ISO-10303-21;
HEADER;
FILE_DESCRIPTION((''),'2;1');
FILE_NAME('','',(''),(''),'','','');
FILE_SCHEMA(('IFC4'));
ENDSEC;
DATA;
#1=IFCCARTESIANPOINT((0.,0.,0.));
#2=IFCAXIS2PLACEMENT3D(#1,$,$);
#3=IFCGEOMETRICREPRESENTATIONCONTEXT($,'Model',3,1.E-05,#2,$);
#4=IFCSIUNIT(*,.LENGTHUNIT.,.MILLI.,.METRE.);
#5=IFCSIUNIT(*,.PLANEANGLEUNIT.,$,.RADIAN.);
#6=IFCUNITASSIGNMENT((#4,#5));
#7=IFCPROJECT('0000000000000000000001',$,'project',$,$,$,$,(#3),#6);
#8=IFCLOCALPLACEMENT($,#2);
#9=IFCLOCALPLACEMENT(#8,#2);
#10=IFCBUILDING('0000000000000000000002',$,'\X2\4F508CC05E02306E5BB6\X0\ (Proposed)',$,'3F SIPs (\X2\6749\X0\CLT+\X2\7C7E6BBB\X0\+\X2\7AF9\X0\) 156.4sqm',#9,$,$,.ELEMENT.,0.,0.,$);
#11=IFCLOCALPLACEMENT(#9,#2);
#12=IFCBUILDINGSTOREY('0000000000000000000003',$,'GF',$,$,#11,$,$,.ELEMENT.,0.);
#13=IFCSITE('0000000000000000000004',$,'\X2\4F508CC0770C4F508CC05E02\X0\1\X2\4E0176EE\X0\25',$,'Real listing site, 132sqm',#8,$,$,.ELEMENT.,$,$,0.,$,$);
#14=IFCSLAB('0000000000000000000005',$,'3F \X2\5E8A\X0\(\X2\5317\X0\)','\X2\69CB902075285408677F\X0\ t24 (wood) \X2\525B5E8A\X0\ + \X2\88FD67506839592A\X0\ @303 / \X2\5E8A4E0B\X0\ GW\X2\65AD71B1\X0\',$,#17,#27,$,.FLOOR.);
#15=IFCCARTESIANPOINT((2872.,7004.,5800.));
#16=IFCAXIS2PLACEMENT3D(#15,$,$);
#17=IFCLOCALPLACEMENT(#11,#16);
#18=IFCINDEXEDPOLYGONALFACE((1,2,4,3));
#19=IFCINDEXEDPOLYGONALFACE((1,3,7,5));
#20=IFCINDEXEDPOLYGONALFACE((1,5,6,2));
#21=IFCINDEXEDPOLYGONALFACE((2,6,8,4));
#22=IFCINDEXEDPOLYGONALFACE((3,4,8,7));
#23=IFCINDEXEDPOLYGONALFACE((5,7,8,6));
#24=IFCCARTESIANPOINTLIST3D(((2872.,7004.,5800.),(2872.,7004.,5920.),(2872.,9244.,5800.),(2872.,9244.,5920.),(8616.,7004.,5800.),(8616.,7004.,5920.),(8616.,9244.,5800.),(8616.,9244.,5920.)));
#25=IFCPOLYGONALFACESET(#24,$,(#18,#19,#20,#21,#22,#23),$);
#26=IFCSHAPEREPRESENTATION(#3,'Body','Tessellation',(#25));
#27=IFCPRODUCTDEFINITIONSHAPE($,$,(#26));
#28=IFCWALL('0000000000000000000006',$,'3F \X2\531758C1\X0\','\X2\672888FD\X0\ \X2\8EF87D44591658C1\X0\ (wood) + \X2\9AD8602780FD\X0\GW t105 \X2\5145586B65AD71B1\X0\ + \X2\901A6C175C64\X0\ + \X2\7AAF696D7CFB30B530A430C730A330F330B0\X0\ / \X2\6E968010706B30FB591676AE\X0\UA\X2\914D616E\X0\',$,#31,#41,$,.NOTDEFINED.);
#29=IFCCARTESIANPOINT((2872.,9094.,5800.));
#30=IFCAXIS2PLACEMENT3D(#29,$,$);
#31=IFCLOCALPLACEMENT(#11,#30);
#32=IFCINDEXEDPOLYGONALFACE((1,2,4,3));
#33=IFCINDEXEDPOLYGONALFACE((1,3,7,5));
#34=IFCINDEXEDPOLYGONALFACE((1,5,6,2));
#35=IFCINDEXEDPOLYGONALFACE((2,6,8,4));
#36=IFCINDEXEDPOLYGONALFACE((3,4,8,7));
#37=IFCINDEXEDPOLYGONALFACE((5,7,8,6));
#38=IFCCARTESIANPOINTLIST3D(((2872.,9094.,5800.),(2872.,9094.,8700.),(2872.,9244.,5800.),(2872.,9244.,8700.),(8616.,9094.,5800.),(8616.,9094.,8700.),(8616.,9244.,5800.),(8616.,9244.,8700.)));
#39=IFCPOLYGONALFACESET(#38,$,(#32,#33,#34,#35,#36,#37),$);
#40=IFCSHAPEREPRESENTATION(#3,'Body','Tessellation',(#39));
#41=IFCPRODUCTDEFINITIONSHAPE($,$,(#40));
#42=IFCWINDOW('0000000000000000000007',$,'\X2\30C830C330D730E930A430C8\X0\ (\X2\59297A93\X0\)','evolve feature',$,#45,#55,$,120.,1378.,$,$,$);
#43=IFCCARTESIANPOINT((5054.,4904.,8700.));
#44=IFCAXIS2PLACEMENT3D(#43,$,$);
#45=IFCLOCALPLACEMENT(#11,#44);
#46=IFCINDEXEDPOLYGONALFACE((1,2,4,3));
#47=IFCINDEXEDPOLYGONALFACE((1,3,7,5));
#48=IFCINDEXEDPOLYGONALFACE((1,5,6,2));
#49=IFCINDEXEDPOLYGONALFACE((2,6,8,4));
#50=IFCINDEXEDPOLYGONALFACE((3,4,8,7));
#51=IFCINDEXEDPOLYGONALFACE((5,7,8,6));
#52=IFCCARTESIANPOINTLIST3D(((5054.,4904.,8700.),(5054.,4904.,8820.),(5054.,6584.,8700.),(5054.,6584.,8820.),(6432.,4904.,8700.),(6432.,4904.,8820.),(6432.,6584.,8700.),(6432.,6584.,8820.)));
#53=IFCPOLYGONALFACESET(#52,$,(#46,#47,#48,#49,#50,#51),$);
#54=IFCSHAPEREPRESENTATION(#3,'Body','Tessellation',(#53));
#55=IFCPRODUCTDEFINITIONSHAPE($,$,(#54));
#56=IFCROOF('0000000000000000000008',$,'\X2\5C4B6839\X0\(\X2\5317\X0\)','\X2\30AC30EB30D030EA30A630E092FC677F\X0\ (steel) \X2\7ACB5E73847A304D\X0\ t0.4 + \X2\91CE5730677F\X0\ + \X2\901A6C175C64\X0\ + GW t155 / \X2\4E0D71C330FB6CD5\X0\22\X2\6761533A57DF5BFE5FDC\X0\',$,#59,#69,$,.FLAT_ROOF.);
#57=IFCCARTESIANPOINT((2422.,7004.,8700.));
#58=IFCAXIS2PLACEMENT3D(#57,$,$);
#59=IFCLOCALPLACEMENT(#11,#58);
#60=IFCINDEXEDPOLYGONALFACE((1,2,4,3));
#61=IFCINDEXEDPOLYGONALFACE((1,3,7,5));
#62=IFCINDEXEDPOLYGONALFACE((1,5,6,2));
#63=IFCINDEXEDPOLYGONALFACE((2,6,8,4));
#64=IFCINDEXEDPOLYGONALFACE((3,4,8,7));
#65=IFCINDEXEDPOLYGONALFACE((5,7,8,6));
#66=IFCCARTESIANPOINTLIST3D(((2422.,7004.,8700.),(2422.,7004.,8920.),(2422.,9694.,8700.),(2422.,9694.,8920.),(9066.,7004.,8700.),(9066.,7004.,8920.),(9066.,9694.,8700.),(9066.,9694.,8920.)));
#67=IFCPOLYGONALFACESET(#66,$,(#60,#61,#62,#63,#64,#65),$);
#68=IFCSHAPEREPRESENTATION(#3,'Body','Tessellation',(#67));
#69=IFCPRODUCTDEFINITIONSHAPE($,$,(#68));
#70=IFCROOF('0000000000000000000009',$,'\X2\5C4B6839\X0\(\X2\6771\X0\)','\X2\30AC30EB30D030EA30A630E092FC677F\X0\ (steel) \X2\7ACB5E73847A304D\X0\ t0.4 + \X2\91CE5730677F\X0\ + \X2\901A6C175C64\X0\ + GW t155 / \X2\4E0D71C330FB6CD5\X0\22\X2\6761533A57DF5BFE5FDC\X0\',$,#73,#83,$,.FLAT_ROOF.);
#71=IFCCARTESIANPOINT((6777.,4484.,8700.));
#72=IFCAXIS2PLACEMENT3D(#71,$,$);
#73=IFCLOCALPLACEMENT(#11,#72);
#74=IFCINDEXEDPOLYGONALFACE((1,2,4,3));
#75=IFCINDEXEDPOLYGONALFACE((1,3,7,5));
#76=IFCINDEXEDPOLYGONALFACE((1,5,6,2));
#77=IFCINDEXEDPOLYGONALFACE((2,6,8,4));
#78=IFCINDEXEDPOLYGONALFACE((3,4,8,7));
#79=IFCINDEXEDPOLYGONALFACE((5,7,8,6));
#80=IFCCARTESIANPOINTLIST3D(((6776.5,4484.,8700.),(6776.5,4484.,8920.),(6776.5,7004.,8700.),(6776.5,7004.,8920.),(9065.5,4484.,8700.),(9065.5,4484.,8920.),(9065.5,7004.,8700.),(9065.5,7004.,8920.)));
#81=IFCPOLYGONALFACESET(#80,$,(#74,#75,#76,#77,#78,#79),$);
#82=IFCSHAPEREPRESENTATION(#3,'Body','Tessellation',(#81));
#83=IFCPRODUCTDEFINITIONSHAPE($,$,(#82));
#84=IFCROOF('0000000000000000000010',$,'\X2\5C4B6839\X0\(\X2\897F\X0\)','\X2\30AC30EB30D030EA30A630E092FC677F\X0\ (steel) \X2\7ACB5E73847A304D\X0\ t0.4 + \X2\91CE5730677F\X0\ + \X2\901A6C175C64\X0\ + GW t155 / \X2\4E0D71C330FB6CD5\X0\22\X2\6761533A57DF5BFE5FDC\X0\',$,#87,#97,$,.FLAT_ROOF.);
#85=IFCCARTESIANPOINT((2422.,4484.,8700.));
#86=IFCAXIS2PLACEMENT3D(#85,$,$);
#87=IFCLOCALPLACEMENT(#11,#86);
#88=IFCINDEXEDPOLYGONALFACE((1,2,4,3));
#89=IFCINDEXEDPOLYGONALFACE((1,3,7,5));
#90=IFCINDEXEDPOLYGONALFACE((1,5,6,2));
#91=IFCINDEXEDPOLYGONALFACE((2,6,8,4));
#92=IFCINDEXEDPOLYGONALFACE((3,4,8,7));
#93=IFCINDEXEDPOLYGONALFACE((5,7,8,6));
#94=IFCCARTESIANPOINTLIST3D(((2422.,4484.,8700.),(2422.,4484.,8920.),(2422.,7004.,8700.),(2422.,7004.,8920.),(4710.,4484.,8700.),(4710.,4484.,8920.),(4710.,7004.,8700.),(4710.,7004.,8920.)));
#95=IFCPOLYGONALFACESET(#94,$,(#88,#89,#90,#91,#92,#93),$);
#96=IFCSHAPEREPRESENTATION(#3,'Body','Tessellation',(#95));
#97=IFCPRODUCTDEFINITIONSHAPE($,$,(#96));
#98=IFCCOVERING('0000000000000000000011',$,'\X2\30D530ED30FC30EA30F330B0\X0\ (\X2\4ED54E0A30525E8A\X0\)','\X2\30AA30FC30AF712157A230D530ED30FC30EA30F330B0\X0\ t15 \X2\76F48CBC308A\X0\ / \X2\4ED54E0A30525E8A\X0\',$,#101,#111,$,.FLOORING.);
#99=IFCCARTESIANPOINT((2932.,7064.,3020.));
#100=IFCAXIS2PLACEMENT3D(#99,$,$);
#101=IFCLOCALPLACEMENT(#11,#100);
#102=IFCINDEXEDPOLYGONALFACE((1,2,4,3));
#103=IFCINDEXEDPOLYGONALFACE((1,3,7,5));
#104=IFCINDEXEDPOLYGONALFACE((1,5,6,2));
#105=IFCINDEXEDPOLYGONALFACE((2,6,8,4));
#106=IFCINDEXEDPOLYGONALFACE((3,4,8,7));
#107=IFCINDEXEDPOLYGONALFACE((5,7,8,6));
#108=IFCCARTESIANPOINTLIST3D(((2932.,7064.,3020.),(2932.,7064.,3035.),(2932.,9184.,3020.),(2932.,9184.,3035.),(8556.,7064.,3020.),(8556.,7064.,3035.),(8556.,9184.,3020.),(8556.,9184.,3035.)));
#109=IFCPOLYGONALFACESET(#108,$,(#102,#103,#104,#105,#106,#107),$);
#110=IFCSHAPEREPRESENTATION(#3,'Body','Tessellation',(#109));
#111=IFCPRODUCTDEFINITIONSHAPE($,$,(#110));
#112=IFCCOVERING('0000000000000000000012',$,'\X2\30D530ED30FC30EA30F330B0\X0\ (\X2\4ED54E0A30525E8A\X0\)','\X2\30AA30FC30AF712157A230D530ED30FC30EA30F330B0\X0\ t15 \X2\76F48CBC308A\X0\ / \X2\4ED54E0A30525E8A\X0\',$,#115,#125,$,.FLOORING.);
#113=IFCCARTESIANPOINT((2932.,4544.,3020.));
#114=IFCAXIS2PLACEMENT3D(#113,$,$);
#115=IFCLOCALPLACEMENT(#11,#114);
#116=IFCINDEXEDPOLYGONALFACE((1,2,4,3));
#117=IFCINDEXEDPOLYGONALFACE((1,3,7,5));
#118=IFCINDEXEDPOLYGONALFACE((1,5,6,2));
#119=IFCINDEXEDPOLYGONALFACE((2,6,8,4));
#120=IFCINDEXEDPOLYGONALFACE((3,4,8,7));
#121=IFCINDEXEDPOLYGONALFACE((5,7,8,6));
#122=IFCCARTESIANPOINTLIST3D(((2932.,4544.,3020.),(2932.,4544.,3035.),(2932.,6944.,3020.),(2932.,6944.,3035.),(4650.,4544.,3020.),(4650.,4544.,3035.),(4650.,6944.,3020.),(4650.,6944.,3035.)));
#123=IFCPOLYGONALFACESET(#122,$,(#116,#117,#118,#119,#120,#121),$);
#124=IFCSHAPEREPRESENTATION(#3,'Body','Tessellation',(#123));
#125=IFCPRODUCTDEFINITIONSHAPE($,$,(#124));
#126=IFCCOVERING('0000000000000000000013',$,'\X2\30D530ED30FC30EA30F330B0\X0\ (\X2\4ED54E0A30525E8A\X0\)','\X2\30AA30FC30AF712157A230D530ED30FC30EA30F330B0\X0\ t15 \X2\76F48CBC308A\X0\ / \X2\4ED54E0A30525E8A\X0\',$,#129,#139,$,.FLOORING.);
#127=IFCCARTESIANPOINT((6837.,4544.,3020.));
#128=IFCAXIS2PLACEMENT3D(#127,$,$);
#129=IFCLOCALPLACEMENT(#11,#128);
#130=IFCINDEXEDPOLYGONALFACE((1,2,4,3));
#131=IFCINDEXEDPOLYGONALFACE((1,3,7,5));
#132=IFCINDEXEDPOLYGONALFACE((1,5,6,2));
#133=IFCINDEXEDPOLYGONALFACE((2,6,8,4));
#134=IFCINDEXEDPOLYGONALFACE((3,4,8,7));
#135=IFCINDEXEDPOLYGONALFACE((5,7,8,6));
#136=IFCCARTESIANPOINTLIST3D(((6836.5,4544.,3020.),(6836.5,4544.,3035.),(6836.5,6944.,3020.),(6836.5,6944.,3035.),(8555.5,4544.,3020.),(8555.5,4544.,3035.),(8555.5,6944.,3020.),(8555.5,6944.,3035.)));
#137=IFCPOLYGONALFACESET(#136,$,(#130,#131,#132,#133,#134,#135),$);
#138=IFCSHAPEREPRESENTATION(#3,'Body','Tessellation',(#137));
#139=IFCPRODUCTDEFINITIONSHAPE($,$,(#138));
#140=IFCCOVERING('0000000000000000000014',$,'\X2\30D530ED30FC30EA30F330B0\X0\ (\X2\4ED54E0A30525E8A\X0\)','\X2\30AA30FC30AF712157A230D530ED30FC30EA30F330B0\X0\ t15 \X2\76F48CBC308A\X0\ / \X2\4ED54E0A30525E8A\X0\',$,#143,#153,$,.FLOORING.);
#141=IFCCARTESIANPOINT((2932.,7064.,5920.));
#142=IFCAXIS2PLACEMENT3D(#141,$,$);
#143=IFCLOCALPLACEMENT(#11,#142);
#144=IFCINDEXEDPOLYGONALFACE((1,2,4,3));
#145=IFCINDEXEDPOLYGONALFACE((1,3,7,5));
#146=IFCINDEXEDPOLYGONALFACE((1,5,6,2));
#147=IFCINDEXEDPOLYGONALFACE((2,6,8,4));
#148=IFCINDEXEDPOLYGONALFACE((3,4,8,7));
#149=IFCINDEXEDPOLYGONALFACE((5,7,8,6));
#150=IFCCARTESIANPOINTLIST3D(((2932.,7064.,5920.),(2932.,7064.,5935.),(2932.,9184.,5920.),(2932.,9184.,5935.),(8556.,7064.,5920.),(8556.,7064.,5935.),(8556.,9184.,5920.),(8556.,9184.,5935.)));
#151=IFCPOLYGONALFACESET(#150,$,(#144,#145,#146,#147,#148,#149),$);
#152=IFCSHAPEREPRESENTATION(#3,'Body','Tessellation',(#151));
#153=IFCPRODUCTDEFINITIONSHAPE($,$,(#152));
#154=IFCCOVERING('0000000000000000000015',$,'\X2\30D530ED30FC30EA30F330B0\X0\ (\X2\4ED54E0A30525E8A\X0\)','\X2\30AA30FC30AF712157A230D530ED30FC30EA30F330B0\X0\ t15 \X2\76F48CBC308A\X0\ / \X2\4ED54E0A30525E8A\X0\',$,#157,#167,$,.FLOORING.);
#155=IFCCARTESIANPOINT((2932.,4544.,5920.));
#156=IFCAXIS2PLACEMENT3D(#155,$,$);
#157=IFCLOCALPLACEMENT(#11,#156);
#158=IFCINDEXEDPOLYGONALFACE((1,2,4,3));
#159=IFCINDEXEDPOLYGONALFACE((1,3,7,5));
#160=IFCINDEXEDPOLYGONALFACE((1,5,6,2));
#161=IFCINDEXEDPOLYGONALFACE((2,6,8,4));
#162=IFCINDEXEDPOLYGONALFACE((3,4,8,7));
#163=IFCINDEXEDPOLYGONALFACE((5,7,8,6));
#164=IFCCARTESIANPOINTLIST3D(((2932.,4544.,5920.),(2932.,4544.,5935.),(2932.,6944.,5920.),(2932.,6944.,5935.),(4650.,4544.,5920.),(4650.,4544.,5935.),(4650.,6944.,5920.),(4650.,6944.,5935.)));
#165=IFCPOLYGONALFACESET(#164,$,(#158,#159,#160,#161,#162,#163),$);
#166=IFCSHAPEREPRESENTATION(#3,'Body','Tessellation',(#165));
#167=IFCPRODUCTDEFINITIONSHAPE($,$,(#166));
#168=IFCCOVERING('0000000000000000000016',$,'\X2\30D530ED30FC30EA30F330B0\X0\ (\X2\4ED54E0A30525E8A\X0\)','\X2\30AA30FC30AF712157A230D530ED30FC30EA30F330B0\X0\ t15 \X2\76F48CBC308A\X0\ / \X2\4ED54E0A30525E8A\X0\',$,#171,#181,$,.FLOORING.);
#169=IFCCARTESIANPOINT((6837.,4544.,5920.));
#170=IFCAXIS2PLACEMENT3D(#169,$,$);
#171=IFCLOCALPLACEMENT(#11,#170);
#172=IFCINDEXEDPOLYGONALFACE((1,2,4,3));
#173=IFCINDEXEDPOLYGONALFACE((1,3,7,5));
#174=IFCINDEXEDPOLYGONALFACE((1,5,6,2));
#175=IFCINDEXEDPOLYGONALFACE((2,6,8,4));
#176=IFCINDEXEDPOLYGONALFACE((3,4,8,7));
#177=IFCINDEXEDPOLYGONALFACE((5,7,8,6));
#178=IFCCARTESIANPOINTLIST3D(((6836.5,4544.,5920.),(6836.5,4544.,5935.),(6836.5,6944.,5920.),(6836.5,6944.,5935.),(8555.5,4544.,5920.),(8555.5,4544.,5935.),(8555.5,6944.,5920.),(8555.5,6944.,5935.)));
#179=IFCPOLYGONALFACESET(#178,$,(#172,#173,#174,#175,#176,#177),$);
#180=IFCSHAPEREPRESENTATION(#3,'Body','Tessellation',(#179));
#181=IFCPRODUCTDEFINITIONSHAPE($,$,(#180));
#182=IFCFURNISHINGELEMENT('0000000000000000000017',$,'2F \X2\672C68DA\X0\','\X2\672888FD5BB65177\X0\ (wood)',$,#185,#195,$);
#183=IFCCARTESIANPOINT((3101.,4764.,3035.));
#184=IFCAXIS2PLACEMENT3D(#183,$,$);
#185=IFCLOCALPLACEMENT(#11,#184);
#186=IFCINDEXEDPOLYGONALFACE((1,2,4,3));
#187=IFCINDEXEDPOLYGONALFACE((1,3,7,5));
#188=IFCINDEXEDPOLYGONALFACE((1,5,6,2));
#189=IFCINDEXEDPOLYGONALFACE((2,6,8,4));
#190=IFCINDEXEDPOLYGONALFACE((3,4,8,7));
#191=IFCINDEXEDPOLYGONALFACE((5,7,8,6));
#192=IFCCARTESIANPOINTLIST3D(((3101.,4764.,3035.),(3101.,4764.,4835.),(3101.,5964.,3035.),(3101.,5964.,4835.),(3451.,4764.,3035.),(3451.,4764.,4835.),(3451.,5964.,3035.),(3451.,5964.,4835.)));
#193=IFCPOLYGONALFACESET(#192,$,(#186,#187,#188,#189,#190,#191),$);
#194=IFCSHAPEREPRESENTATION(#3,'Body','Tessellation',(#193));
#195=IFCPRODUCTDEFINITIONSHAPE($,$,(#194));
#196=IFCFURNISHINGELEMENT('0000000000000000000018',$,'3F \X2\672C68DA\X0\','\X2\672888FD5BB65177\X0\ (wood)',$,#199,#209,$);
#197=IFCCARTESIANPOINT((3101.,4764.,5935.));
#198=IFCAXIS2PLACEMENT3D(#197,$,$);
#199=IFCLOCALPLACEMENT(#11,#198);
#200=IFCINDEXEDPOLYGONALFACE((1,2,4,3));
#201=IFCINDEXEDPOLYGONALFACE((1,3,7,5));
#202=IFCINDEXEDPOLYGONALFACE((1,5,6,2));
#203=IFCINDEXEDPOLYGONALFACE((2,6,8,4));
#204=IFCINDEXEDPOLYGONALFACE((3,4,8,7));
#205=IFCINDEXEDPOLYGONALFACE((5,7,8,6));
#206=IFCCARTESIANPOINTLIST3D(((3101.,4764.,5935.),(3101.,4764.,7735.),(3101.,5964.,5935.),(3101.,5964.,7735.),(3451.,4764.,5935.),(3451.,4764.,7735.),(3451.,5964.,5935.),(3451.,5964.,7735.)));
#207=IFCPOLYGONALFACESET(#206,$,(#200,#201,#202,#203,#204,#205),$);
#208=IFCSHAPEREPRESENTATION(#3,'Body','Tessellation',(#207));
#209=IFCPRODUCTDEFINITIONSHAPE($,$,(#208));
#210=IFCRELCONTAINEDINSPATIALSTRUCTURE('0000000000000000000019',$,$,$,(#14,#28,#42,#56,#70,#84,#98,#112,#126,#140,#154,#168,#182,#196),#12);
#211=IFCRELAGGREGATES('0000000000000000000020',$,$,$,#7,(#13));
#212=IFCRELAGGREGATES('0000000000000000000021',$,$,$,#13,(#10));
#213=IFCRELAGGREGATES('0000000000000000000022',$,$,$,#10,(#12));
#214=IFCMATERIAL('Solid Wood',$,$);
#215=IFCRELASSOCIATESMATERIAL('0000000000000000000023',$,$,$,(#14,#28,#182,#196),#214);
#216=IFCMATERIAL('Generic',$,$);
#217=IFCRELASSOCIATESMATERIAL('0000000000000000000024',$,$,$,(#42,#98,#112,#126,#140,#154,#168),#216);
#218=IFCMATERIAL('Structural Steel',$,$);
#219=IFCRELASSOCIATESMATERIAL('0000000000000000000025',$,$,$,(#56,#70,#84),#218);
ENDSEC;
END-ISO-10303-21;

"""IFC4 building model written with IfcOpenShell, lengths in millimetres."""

from ifc_helpers import new_model, si_unit, frame, frame_2d, origin, place, context, project, spatial, rectangle, extrude, material, element, save


model = new_model("IFC4")

# Units and contexts
model_context = context("Model", 3, precision=1e-05, world=origin())
ifc_project = project(units=[si_unit("LENGTHUNIT", "METRE", prefix="MILLI"), si_unit("PLANEANGLEUNIT", "RADIAN")], contexts=[model_context])

# Site, building, storey
site_placement = place(None, origin())
site = spatial("IfcSite", under=ifc_project, at=site_placement, Name="佐賀県佐賀市1丁目25", ObjectType="Real listing site, 132sqm", CompositionType="ELEMENT", RefElevation=0.0)
building_placement = place(site_placement, origin())
building = spatial("IfcBuilding", under=site, at=building_placement, Name="佐賀市の家 (Proposed)", ObjectType="3F SIPs (杉CLT+籾殻+竹) 156.4sqm", CompositionType="ELEMENT", ElevationOfRefHeight=0.0, ElevationOfTerrain=0.0)
storey_placement = place(building_placement, origin())
storey = spatial("IfcBuildingStorey", under=building, at=storey_placement, Name="GF", CompositionType="ELEMENT", Elevation=0.0)

# Slab
ifc_material_1 = material(Name="Solid Wood")
slab_placement = place(storey_placement, frame((2872.0, 7004.0, 5800.0)))
element("IfcSlab", 1, at=slab_placement, inside=storey, material=ifc_material_1, Name="3F 床(北)", Description="構造用合板 t24 (wood) 剛床 + 製材根太 @303 / 床下 GW断熱", PredefinedType="FLOOR", context=model_context, shape_type="SweptSolid", body=[
    extrude(rectangle(XDim=5744.0, YDim=2240.0, at=frame_2d((2872.0, 1120.0))), frame((2872.0, 7004.0, 5800.0)), (0.0, 0.0, 1.0), 120.0),
])

# Wall
wall_1_placement = place(storey_placement, frame((2872.0, 9094.0, 5800.0)))
element("IfcWall", 2, at=wall_1_placement, inside=storey, material=ifc_material_1, Name="3F 北壁", Description="木製 軸組外壁 (wood) + 高性能GW t105 充填断熱 + 通気層 + 窯業系サイディング / 準耐火・外皮UA配慮", PredefinedType="NOTDEFINED", context=model_context, shape_type="SweptSolid", body=[
    extrude(rectangle(XDim=5744.0, YDim=150.0, at=frame_2d((2872.0, 75.0))), frame((2872.0, 9094.0, 5800.0)), (0.0, 0.0, 1.0), 2900.0),
])

# Window
ifc_material_2 = material(Name="Generic")
window_1_placement = place(storey_placement, frame((5054.0, 4904.0, 8700.0)))
element("IfcWindow", 3, at=window_1_placement, inside=storey, material=ifc_material_2, Name="トップライト (天窓)", Description="evolve feature", OverallHeight=120.0, OverallWidth=1378.0, context=model_context, shape_type="SweptSolid", body=[
    extrude(rectangle(XDim=1378.0, YDim=1680.0, at=frame_2d((689.0, 840.0))), frame((5054.0, 4904.0, 8700.0)), (0.0, 0.0, 1.0), 120.0),
])

# Roofs
ifc_material_3 = material(Name="Structural Steel")
roof_1_placement = place(storey_placement, frame((2422.0, 7004.0, 8700.0)))
element("IfcRoof", 4, at=roof_1_placement, inside=storey, material=ifc_material_3, Name="屋根(北)", Description="ガルバリウム鋼板 (steel) 立平葺き t0.4 + 野地板 + 通気層 + GW t155 / 不燃・法22条区域対応", PredefinedType="FLAT_ROOF", context=model_context, shape_type="SweptSolid", body=[
    extrude(rectangle(XDim=6644.0, YDim=2690.0, at=frame_2d((3322.0, 1345.0))), frame((2422.0, 7004.0, 8700.0)), (0.0, 0.0, 1.0), 220.0),
])
roof_2_placement = place(storey_placement, frame((6777.0, 4484.0, 8700.0)))
element("IfcRoof", 5, at=roof_2_placement, inside=storey, material=ifc_material_3, Name="屋根(東)", Description="ガルバリウム鋼板 (steel) 立平葺き t0.4 + 野地板 + 通気層 + GW t155 / 不燃・法22条区域対応", PredefinedType="FLAT_ROOF", context=model_context, shape_type="SweptSolid", body=[
    extrude(rectangle(XDim=2289.0, YDim=2520.0, at=frame_2d((1144.0, 1260.0))), frame((6777.0, 4484.0, 8700.0)), (0.0, 0.0, 1.0), 220.0),
])
roof_3_placement = place(storey_placement, frame((2422.0, 4484.0, 8700.0)))
element("IfcRoof", 6, at=roof_3_placement, inside=storey, material=ifc_material_3, Name="屋根(西)", Description="ガルバリウム鋼板 (steel) 立平葺き t0.4 + 野地板 + 通気層 + GW t155 / 不燃・法22条区域対応", PredefinedType="FLAT_ROOF", context=model_context, shape_type="SweptSolid", body=[
    extrude(rectangle(XDim=2288.0, YDim=2520.0, at=frame_2d((1144.0, 1260.0))), frame((2422.0, 4484.0, 8700.0)), (0.0, 0.0, 1.0), 220.0),
])

# Coverings
covering_1_placement = place(storey_placement, frame((2932.0, 7064.0, 3020.0)))
element("IfcCovering", 7, at=covering_1_placement, inside=storey, material=ifc_material_2, Name="フローリング (仕上げ床)", Description="オーク無垢フローリング t15 直貼り / 仕上げ床", PredefinedType="FLOORING", context=model_context, shape_type="SweptSolid", body=[
    extrude(rectangle(XDim=5624.0, YDim=2120.0, at=frame_2d((2812.0, 1060.0))), frame((2932.0, 7064.0, 3020.0)), (0.0, 0.0, 1.0), 15.0),
])
covering_2_placement = place(storey_placement, frame((2932.0, 4544.0, 3020.0)))
element("IfcCovering", 8, at=covering_2_placement, inside=storey, material=ifc_material_2, Name="フローリング (仕上げ床)", Description="オーク無垢フローリング t15 直貼り / 仕上げ床", PredefinedType="FLOORING", context=model_context, shape_type="SweptSolid", body=[
    extrude(rectangle(XDim=1718.0, YDim=2400.0, at=frame_2d((859.0, 1200.0))), frame((2932.0, 4544.0, 3020.0)), (0.0, 0.0, 1.0), 15.0),
])
covering_3_placement = place(storey_placement, frame((6837.0, 4544.0, 3020.0)))
element("IfcCovering", 9, at=covering_3_placement, inside=storey, material=ifc_material_2, Name="フローリング (仕上げ床)", Description="オーク無垢フローリング t15 直貼り / 仕上げ床", PredefinedType="FLOORING", context=model_context, shape_type="SweptSolid", body=[
    extrude(rectangle(XDim=1719.0, YDim=2400.0, at=frame_2d((859.0, 1200.0))), frame((6837.0, 4544.0, 3020.0)), (0.0, 0.0, 1.0), 15.0),
])
covering_4_placement = place(storey_placement, frame((2932.0, 7064.0, 5920.0)))
element("IfcCovering", 10, at=covering_4_placement, inside=storey, material=ifc_material_2, Name="フローリング (仕上げ床)", Description="オーク無垢フローリング t15 直貼り / 仕上げ床", PredefinedType="FLOORING", context=model_context, shape_type="SweptSolid", body=[
    extrude(rectangle(XDim=5624.0, YDim=2120.0, at=frame_2d((2812.0, 1060.0))), frame((2932.0, 7064.0, 5920.0)), (0.0, 0.0, 1.0), 15.0),
])
covering_5_placement = place(storey_placement, frame((2932.0, 4544.0, 5920.0)))
element("IfcCovering", 11, at=covering_5_placement, inside=storey, material=ifc_material_2, Name="フローリング (仕上げ床)", Description="オーク無垢フローリング t15 直貼り / 仕上げ床", PredefinedType="FLOORING", context=model_context, shape_type="SweptSolid", body=[
    extrude(rectangle(XDim=1718.0, YDim=2400.0, at=frame_2d((859.0, 1200.0))), frame((2932.0, 4544.0, 5920.0)), (0.0, 0.0, 1.0), 15.0),
])
covering_6_placement = place(storey_placement, frame((6837.0, 4544.0, 5920.0)))
element("IfcCovering", 12, at=covering_6_placement, inside=storey, material=ifc_material_2, Name="フローリング (仕上げ床)", Description="オーク無垢フローリング t15 直貼り / 仕上げ床", PredefinedType="FLOORING", context=model_context, shape_type="SweptSolid", body=[
    extrude(rectangle(XDim=1719.0, YDim=2400.0, at=frame_2d((859.0, 1200.0))), frame((6837.0, 4544.0, 5920.0)), (0.0, 0.0, 1.0), 15.0),
])

# Furnishing elements
furnishing_1_placement = place(storey_placement, frame((3101.0, 4764.0, 3035.0)))
element("IfcFurnishingElement", 13, at=furnishing_1_placement, inside=storey, material=ifc_material_1, Name="2F 本棚", Description="木製家具 (wood)", context=model_context, shape_type="SweptSolid", body=[
    extrude(rectangle(XDim=350.0, YDim=1200.0, at=frame_2d((175.0, 600.0))), frame((3101.0, 4764.0, 3035.0)), (0.0, 0.0, 1.0), 1800.0),
])
furnishing_2_placement = place(storey_placement, frame((3101.0, 4764.0, 5935.0)))
element("IfcFurnishingElement", 14, at=furnishing_2_placement, inside=storey, material=ifc_material_1, Name="3F 本棚", Description="木製家具 (wood)", context=model_context, shape_type="SweptSolid", body=[
    extrude(rectangle(XDim=350.0, YDim=1200.0, at=frame_2d((175.0, 600.0))), frame((3101.0, 4764.0, 5935.0)), (0.0, 0.0, 1.0), 1800.0),
])

save(model, "model.ifc")
